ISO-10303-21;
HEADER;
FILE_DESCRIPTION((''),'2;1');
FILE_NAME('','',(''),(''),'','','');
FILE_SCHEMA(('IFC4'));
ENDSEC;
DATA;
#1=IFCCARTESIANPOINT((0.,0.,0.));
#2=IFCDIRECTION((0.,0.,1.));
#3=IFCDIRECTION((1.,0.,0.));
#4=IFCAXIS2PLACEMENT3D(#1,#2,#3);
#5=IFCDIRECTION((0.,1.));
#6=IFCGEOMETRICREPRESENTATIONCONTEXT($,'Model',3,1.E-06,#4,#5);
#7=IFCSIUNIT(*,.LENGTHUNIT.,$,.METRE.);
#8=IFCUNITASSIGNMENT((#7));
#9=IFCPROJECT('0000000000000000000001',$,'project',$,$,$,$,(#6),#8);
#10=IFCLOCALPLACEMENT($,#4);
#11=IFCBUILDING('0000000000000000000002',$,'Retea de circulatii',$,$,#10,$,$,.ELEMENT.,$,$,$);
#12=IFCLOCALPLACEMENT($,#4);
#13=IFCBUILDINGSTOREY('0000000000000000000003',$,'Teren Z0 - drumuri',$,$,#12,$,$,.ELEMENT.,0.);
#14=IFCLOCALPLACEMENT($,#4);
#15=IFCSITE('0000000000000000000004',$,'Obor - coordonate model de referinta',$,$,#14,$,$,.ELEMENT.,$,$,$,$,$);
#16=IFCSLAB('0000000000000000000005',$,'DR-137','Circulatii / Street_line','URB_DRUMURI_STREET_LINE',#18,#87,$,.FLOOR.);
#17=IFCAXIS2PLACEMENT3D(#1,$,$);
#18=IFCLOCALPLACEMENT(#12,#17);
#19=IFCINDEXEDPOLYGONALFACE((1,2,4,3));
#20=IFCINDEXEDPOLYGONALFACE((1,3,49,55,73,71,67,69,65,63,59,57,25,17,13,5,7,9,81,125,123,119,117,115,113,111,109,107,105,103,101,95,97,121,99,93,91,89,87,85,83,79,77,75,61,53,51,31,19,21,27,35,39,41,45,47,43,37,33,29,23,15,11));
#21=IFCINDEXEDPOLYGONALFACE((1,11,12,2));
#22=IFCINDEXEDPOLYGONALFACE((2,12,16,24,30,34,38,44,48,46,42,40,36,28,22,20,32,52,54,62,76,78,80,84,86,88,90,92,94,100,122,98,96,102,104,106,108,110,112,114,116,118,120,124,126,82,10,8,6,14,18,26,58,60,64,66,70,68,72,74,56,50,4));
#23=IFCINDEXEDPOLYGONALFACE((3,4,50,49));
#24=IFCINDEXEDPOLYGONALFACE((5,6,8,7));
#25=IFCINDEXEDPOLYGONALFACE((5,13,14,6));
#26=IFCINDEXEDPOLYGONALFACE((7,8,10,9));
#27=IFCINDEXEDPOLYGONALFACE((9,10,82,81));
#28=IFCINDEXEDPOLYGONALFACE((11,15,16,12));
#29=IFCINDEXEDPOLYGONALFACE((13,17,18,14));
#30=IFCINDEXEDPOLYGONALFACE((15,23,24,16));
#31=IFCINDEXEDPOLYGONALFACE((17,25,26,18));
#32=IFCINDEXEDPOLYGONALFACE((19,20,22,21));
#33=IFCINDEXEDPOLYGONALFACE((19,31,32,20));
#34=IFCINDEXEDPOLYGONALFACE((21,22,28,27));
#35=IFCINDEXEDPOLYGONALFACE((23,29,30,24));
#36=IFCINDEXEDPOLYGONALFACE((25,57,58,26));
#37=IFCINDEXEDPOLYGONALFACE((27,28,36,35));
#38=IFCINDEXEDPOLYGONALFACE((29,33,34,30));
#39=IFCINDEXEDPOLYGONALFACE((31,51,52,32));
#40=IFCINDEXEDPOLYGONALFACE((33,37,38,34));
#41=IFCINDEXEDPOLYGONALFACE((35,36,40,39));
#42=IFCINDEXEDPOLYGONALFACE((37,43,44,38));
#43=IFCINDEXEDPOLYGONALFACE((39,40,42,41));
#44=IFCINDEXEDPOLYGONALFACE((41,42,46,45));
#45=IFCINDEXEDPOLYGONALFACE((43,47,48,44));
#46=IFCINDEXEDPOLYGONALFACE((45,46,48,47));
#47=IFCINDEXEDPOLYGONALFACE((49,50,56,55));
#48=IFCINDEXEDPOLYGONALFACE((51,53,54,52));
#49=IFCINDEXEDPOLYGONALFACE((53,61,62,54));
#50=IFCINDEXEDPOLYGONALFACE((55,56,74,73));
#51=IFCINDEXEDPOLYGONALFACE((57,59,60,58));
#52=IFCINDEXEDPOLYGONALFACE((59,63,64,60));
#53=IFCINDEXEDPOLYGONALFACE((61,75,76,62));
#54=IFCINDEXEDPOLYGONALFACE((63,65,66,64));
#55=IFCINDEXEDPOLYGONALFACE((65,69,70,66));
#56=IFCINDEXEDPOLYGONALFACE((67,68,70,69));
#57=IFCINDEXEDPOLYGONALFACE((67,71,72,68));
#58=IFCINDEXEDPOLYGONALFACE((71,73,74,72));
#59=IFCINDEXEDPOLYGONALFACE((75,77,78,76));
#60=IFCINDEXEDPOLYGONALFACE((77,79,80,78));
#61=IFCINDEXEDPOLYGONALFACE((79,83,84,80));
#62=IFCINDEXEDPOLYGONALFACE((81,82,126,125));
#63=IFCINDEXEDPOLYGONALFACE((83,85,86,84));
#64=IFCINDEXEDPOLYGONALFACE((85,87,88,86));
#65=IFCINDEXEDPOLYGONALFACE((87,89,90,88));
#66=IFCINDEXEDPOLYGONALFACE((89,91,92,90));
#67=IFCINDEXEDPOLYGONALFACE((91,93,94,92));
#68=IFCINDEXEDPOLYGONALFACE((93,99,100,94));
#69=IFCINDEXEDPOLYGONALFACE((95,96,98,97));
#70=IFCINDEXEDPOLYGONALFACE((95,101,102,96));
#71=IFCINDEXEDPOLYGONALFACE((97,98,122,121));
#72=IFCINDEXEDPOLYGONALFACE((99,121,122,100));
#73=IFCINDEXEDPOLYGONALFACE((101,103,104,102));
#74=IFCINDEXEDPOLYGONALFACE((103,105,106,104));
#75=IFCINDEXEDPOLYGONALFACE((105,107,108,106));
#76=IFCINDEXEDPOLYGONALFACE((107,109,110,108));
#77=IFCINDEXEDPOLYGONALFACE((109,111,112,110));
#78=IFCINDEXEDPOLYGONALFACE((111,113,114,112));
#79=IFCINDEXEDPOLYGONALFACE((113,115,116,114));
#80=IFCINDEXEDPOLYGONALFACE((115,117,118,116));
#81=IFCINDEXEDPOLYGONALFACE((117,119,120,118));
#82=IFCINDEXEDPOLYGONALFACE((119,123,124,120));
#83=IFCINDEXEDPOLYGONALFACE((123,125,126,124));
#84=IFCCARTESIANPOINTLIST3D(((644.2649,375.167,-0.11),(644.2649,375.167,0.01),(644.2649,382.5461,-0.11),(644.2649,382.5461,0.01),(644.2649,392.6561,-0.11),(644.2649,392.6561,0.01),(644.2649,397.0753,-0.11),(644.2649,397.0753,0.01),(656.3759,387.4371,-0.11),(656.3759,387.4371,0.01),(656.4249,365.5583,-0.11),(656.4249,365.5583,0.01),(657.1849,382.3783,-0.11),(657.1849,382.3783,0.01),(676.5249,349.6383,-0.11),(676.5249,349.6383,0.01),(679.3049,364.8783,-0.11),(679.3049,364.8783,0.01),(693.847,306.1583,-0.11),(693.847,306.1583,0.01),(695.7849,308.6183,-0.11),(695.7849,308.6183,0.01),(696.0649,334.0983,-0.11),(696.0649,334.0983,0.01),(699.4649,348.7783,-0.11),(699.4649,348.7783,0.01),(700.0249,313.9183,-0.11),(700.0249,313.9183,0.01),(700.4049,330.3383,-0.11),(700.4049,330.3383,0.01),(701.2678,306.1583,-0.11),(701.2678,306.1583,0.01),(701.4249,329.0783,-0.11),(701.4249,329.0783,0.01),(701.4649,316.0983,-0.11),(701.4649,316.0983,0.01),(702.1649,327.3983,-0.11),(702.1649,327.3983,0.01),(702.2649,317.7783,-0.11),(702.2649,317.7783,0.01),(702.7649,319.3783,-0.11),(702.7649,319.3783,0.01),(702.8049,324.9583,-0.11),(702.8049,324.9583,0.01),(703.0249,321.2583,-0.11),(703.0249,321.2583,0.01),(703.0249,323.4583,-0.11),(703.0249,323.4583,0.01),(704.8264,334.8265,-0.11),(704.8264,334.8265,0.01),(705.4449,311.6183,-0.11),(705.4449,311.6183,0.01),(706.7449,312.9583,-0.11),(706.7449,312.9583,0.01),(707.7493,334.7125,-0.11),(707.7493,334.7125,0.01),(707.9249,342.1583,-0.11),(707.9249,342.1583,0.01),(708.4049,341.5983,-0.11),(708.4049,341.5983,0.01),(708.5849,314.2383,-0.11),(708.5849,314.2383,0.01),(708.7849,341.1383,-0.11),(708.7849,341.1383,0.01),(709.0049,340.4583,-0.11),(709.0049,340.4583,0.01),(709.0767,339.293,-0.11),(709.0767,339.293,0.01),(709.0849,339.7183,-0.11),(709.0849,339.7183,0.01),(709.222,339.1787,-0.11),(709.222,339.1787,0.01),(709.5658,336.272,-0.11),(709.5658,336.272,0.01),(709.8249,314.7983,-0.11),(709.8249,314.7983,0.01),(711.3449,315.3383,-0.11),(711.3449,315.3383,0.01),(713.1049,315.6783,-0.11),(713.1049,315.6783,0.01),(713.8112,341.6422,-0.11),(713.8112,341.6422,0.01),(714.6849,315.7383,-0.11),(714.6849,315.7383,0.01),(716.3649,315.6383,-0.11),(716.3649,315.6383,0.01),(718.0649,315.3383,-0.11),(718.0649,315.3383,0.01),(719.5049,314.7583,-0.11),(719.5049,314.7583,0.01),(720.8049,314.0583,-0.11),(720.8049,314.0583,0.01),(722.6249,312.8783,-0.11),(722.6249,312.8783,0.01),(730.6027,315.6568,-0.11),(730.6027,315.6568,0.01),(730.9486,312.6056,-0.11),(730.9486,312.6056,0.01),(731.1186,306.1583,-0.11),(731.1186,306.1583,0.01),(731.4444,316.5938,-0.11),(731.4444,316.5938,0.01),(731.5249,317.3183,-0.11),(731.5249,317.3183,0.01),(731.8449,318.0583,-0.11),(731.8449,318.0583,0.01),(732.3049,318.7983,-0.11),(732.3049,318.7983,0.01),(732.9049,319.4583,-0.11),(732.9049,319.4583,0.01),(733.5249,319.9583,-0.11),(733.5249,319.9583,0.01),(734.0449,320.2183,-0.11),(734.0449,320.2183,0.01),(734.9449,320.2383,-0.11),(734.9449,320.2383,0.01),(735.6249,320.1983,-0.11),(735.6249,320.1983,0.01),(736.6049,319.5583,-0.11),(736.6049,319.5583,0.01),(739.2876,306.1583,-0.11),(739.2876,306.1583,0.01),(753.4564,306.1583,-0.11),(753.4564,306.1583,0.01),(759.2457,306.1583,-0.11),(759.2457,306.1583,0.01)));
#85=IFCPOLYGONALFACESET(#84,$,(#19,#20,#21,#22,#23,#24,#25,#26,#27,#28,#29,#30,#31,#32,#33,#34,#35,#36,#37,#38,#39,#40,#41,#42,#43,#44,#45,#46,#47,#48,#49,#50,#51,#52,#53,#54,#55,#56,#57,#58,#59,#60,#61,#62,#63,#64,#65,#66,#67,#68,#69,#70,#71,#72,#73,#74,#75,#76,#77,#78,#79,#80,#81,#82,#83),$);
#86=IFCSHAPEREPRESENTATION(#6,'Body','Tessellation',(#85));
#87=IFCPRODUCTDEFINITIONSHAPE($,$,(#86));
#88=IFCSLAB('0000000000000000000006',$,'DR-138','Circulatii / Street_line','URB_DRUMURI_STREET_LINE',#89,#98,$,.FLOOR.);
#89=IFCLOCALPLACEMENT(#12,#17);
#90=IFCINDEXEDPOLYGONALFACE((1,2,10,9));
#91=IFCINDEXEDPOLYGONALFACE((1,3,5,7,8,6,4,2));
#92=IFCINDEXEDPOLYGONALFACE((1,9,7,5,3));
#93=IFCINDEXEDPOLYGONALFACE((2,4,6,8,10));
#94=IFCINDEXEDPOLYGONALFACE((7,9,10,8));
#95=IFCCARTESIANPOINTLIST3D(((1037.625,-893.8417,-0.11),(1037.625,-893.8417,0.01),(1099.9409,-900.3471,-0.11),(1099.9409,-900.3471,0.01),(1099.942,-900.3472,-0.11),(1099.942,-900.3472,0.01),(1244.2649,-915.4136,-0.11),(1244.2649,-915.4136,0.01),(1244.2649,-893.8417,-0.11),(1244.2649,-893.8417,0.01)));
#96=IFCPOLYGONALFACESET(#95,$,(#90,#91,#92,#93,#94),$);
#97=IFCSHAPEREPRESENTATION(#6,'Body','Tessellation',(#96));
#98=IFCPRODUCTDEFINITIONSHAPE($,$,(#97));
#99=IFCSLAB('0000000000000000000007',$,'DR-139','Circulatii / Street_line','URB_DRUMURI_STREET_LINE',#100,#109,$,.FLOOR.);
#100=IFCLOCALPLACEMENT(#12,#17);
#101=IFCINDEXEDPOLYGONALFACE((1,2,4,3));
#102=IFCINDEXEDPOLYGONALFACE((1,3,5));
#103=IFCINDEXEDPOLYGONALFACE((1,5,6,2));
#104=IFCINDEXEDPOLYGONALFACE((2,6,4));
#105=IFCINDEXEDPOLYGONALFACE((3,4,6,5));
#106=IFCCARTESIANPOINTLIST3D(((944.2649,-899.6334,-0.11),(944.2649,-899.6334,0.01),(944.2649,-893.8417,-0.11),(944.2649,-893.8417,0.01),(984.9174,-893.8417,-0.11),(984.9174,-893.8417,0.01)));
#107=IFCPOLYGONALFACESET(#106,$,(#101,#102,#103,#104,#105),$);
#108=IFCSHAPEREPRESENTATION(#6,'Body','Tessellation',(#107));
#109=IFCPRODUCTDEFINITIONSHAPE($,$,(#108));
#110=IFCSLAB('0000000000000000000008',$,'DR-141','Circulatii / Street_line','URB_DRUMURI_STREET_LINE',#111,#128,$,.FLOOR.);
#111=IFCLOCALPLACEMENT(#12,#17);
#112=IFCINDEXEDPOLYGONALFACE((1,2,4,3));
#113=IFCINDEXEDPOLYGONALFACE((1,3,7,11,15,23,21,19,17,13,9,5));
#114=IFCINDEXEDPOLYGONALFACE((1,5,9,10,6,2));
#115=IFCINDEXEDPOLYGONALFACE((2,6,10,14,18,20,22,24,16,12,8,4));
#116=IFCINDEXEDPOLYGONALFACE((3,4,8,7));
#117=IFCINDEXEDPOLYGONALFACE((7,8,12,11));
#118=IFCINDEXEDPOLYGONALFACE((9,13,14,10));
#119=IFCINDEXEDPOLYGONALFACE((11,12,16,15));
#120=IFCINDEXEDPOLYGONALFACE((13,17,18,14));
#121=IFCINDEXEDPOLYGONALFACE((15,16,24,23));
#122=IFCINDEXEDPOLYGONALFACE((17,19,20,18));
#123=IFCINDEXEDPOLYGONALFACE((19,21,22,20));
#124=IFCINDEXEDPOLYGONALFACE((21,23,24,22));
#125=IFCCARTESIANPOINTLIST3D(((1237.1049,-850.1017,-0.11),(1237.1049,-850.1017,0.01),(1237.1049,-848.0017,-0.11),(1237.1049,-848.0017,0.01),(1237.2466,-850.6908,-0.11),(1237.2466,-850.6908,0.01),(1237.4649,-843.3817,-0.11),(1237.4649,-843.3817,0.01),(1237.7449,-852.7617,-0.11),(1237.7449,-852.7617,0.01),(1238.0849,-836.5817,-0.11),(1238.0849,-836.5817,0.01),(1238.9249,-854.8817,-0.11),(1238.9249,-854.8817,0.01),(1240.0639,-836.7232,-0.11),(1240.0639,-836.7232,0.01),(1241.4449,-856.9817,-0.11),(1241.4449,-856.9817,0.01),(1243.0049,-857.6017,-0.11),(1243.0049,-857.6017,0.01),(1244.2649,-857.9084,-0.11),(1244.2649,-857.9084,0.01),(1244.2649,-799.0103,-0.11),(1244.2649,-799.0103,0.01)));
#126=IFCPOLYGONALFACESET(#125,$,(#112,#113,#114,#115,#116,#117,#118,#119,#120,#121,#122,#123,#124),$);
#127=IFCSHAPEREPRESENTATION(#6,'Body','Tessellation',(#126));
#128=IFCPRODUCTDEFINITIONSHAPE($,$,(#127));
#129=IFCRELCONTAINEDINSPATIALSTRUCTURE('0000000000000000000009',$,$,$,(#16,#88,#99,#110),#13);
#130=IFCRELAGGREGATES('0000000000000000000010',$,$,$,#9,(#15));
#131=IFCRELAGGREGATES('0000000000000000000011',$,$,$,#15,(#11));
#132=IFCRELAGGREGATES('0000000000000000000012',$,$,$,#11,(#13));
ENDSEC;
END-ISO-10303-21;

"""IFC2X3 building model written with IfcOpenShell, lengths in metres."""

from ifc_helpers import new_model, si_unit, direction, frame, origin_with_axes, place, context, project, spatial, polyline, outline, extrude, element, save


model = new_model("IFC2X3")

# Units and contexts
model_context = context("Model", 3, precision=1e-06, world=origin_with_axes(), true_north=direction((0.0, 1.0)))
ifc_project = project(units=[si_unit("LENGTHUNIT", "METRE")], contexts=[model_context])

# Site, building, storey
site_placement = place(None, origin_with_axes())
site = spatial("IfcSite", under=ifc_project, at=site_placement, Name="Obor - coordonate model de referinta", CompositionType="ELEMENT")
building_placement = place(None, origin_with_axes())
building = spatial("IfcBuilding", under=site, at=building_placement, Name="Retea de circulatii", CompositionType="ELEMENT")
storey_placement = place(None, origin_with_axes())
storey = spatial("IfcBuildingStorey", under=building, at=storey_placement, Name="Teren Z0 - drumuri", CompositionType="ELEMENT", Elevation=0.0)

# Slabs
slab_1_placement = place(None, origin_with_axes())
element("IfcSlab", 1, at=slab_1_placement, inside=storey, Name="DR-137", Description="Circulatii / Street_line", ObjectType="URB_DRUMURI_STREET_LINE", PredefinedType="FLOOR", context=model_context, shape_type="SweptSolid", body=[
    extrude(outline(polyline([(713.8112, 341.6422), (656.3759, 387.4371), (644.2649, 397.0753), (644.2649, 392.6561), (657.1849, 382.3783), (679.3049, 364.8783), (699.4649, 348.7783), (707.9249, 342.1583), (708.4049, 341.5983), (708.7849, 341.1383), (709.0049, 340.4583), (709.0849, 339.7183), (709.0767, 339.293), (709.222, 339.1787), (709.5658, 336.272), (707.7493, 334.7125), (704.8264, 334.8265), (644.2649, 382.5461), (644.2649, 375.167), (656.4249, 365.5583), (676.5249, 349.6383), (696.0649, 334.0983), (700.4049, 330.3383), (701.4249, 329.0783), (702.1649, 327.3983), (702.8049, 324.9583), (703.0249, 323.4583), (703.0249, 321.2583), (702.7649, 319.3783), (702.2649, 317.7783), (701.4649, 316.0983), (700.0249, 313.9183), (695.7849, 308.6183), (693.847, 306.1583), (701.2678, 306.1583), (705.4449, 311.6183), (706.7449, 312.9583), (708.5849, 314.2383), (709.8249, 314.7983), (711.3449, 315.3383), (713.1049, 315.6783), (714.6849, 315.7383), (716.3649, 315.6383), (718.0649, 315.3383), (719.5049, 314.7583), (720.8049, 314.0583), (722.6249, 312.8783), (731.1186, 306.1583), (739.2876, 306.1583), (730.9486, 312.6056), (730.6027, 315.6568), (731.4444, 316.5938), (731.5249, 317.3183), (731.8449, 318.0583), (732.3049, 318.7983), (732.9049, 319.4583), (733.5249, 319.9583), (734.0449, 320.2183), (734.9449, 320.2383), (735.6249, 320.1983), (736.6049, 319.5583), (753.4564, 306.1583), (759.2457, 306.1583), (713.8112, 341.6422)])), frame((0.0, 0.0, -0.11), z_axis=(0.0, 0.0, 1.0), x_axis=(1.0, 0.0, 0.0)), (0.0, 0.0, 1.0), 0.12),
])
slab_2_placement = place(None, origin_with_axes())
element("IfcSlab", 2, at=slab_2_placement, inside=storey, Name="DR-138", Description="Circulatii / Street_line", ObjectType="URB_DRUMURI_STREET_LINE", PredefinedType="FLOOR", context=model_context, shape_type="SweptSolid", body=[
    extrude(outline(polyline([(1099.9409, -900.3471), (1099.942, -900.3472), (1244.2649, -915.4136), (1244.2649, -893.8417), (1037.625, -893.8417), (1099.9409, -900.3471)])), frame((0.0, 0.0, -0.11), z_axis=(0.0, 0.0, 1.0), x_axis=(1.0, 0.0, 0.0)), (0.0, 0.0, 1.0), 0.12),
])
slab_3_placement = place(None, origin_with_axes())
element("IfcSlab", 3, at=slab_3_placement, inside=storey, Name="DR-139", Description="Circulatii / Street_line", ObjectType="URB_DRUMURI_STREET_LINE", PredefinedType="FLOOR", context=model_context, shape_type="SweptSolid", body=[
    extrude(outline(polyline([(944.2649, -893.8417), (944.2649, -899.6334), (984.9174, -893.8417), (944.2649, -893.8417)])), frame((0.0, 0.0, -0.11), z_axis=(0.0, 0.0, 1.0), x_axis=(1.0, 0.0, 0.0)), (0.0, 0.0, 1.0), 0.12),
])
slab_4_placement = place(None, origin_with_axes())
element("IfcSlab", 4, at=slab_4_placement, inside=storey, Name="DR-141", Description="Circulatii / Street_line", ObjectType="URB_DRUMURI_STREET_LINE", PredefinedType="FLOOR", context=model_context, shape_type="SweptSolid", body=[
    extrude(outline(polyline([(1237.7449, -852.7617), (1238.9249, -854.8817), (1241.4449, -856.9817), (1243.0049, -857.6017), (1244.2649, -857.9084), (1244.2649, -799.0103), (1240.0639, -836.7232), (1238.0849, -836.5817), (1237.4649, -843.3817), (1237.1049, -848.0017), (1237.1049, -850.1017), (1237.2466, -850.6908), (1237.7449, -852.7617)])), frame((0.0, 0.0, -0.11), z_axis=(0.0, 0.0, 1.0), x_axis=(1.0, 0.0, 0.0)), (0.0, 0.0, 1.0), 0.12),
])

save(model, "model.ifc")
